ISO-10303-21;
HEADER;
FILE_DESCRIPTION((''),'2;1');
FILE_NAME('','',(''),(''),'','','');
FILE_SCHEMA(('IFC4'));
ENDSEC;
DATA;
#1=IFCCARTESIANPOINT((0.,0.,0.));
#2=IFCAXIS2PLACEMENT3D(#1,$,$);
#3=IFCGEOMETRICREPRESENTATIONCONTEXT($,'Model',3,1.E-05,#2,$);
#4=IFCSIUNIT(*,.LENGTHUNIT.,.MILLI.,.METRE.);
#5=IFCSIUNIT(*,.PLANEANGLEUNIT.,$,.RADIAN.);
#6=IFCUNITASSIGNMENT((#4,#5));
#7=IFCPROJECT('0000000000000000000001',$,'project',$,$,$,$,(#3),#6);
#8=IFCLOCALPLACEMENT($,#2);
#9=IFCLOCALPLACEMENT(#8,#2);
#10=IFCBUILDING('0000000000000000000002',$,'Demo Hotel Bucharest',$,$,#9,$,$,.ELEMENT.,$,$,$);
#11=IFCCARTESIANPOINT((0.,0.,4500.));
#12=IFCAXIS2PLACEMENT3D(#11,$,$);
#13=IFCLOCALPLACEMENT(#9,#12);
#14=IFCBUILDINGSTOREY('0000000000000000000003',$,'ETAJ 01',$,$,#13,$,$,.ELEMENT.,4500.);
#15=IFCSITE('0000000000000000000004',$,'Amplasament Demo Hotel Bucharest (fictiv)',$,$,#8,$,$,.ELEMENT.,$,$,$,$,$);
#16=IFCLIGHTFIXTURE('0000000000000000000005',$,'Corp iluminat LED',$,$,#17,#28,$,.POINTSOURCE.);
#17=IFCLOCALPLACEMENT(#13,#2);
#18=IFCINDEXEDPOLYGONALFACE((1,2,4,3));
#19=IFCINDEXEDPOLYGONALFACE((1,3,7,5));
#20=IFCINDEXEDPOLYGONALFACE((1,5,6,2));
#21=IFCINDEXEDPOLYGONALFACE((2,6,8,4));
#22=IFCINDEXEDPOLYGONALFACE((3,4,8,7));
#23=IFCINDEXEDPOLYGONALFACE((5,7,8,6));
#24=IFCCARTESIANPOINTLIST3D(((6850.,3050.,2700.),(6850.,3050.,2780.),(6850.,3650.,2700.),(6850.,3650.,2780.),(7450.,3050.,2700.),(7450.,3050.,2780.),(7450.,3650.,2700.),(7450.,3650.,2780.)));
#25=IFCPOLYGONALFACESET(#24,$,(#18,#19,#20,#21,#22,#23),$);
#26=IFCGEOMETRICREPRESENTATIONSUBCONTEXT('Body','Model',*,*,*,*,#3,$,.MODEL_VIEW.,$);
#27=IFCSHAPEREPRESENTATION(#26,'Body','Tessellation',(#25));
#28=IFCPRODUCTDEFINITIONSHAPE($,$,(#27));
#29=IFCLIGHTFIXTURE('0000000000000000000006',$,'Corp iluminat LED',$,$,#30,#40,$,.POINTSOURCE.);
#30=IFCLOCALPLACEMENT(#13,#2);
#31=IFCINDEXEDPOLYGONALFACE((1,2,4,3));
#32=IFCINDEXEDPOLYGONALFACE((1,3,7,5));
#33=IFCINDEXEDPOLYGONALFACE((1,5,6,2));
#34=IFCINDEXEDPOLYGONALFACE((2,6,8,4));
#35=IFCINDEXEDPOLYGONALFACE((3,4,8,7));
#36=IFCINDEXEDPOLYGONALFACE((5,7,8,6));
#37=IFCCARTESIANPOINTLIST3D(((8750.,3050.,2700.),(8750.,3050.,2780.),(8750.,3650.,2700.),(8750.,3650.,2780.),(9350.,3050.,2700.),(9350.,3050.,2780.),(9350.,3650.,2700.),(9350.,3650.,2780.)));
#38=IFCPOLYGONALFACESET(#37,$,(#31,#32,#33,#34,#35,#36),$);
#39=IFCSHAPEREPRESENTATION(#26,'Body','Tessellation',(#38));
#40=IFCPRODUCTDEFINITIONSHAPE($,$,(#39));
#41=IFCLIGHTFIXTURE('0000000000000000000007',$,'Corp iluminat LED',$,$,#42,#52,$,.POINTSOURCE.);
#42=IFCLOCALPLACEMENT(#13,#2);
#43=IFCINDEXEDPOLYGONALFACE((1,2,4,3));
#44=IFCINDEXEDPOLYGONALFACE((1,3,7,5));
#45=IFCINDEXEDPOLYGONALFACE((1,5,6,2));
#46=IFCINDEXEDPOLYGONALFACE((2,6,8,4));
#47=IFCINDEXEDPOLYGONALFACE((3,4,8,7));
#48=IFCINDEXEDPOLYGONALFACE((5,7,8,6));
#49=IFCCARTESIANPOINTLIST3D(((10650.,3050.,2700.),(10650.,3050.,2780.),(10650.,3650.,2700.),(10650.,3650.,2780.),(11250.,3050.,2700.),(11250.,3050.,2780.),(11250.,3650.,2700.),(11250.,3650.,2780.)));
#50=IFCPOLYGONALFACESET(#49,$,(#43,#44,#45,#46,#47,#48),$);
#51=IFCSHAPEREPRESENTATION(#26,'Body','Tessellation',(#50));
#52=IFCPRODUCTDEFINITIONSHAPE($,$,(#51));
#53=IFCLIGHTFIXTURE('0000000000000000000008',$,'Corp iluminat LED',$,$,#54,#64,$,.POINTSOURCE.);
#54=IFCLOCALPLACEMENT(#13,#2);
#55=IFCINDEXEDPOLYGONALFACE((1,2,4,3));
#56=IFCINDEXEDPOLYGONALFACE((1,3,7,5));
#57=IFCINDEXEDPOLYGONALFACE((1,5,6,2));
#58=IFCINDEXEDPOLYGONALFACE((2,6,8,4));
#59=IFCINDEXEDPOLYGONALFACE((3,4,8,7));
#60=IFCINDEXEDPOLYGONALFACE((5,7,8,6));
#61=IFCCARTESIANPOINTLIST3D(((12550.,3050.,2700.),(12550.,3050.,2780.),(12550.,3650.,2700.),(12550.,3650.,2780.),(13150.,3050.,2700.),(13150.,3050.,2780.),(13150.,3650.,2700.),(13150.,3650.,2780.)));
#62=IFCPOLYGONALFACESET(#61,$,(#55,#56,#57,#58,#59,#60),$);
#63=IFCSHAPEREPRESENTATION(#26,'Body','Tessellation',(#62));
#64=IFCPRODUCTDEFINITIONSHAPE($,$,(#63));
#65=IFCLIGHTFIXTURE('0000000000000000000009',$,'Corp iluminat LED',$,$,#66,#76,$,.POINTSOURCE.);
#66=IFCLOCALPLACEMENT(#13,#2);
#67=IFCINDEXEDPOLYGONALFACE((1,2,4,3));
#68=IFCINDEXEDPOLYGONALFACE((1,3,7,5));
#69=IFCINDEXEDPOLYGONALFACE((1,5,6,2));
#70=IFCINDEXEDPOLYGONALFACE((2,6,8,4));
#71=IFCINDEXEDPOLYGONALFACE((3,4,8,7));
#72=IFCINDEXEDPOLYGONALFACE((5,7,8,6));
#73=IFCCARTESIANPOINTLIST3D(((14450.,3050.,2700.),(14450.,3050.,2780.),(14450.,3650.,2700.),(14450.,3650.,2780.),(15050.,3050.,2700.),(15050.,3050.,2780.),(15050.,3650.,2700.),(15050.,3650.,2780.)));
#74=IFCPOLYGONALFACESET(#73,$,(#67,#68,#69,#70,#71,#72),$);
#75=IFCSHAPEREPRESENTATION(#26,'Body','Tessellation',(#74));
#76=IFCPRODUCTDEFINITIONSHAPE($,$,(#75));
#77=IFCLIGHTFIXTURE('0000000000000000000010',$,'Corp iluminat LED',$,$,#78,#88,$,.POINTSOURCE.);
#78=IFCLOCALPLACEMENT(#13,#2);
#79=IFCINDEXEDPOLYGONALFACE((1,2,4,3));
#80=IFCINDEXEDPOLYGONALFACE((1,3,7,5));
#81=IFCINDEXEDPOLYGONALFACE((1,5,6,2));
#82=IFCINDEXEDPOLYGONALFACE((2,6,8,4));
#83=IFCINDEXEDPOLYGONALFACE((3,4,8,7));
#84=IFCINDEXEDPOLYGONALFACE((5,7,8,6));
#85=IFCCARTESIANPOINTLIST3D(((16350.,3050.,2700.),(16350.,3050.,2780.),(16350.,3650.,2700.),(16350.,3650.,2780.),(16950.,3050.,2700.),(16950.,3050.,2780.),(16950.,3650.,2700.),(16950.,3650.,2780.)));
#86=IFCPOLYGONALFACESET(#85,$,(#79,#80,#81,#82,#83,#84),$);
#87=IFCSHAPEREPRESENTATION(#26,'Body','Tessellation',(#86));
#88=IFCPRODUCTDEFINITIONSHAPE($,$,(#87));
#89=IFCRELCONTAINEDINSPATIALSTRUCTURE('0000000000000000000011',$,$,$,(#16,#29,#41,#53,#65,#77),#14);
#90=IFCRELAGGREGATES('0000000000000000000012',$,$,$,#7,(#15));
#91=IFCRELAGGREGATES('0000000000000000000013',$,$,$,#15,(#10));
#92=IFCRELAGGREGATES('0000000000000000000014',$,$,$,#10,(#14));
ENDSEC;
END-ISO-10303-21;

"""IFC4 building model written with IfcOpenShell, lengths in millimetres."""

from ifc_helpers import new_model, si_unit, frame, frame_2d, origin, place, context, subcontext, project, spatial, rectangle, extrude, element, save


model = new_model("IFC4")

# Units and contexts
model_context = context("Model", 3, precision=1e-05, world=origin())
body_context = subcontext(model_context, "Body", "Model", "MODEL_VIEW")
ifc_project = project(units=[si_unit("LENGTHUNIT", "METRE", prefix="MILLI"), si_unit("PLANEANGLEUNIT", "RADIAN")], contexts=[model_context])

# Site, building, storey
site_placement = place(None, origin())
site = spatial("IfcSite", under=ifc_project, at=site_placement, Name="Amplasament Demo Hotel Bucharest (fictiv)", CompositionType="ELEMENT")
building_placement = place(site_placement, origin())
building = spatial("IfcBuilding", under=site, at=building_placement, Name="Demo Hotel Bucharest", CompositionType="ELEMENT")
storey_placement = place(building_placement, frame((0.0, 0.0, 4500.0)))
storey = spatial("IfcBuildingStorey", under=building, at=storey_placement, Name="ETAJ 01", CompositionType="ELEMENT", Elevation=4500.0)

# Light fixtures
for number, where, name in (
    (1, (6850.0, 3050.0, 2700.0), "Corp iluminat LED"),
    (2, (8750.0, 3050.0, 2700.0), "Corp iluminat LED"),
    (3, (10650.0, 3050.0, 2700.0), "Corp iluminat LED"),
    (4, (12550.0, 3050.0, 2700.0), "Corp iluminat LED"),
    (5, (14450.0, 3050.0, 2700.0), "Corp iluminat LED"),
    (6, (16350.0, 3050.0, 2700.0), "Corp iluminat LED"),
):
    element("IfcLightFixture", number, at=place(storey_placement, frame(where)), inside=storey, Name=name, PredefinedType="POINTSOURCE", context=body_context, shape_type="SweptSolid", body=[
        extrude(rectangle(XDim=600.0, YDim=600.0, at=frame_2d((300.0, 300.0))), origin(), (0.0, 0.0, 1.0), 80.0),
    ])

save(model, "model.ifc")
